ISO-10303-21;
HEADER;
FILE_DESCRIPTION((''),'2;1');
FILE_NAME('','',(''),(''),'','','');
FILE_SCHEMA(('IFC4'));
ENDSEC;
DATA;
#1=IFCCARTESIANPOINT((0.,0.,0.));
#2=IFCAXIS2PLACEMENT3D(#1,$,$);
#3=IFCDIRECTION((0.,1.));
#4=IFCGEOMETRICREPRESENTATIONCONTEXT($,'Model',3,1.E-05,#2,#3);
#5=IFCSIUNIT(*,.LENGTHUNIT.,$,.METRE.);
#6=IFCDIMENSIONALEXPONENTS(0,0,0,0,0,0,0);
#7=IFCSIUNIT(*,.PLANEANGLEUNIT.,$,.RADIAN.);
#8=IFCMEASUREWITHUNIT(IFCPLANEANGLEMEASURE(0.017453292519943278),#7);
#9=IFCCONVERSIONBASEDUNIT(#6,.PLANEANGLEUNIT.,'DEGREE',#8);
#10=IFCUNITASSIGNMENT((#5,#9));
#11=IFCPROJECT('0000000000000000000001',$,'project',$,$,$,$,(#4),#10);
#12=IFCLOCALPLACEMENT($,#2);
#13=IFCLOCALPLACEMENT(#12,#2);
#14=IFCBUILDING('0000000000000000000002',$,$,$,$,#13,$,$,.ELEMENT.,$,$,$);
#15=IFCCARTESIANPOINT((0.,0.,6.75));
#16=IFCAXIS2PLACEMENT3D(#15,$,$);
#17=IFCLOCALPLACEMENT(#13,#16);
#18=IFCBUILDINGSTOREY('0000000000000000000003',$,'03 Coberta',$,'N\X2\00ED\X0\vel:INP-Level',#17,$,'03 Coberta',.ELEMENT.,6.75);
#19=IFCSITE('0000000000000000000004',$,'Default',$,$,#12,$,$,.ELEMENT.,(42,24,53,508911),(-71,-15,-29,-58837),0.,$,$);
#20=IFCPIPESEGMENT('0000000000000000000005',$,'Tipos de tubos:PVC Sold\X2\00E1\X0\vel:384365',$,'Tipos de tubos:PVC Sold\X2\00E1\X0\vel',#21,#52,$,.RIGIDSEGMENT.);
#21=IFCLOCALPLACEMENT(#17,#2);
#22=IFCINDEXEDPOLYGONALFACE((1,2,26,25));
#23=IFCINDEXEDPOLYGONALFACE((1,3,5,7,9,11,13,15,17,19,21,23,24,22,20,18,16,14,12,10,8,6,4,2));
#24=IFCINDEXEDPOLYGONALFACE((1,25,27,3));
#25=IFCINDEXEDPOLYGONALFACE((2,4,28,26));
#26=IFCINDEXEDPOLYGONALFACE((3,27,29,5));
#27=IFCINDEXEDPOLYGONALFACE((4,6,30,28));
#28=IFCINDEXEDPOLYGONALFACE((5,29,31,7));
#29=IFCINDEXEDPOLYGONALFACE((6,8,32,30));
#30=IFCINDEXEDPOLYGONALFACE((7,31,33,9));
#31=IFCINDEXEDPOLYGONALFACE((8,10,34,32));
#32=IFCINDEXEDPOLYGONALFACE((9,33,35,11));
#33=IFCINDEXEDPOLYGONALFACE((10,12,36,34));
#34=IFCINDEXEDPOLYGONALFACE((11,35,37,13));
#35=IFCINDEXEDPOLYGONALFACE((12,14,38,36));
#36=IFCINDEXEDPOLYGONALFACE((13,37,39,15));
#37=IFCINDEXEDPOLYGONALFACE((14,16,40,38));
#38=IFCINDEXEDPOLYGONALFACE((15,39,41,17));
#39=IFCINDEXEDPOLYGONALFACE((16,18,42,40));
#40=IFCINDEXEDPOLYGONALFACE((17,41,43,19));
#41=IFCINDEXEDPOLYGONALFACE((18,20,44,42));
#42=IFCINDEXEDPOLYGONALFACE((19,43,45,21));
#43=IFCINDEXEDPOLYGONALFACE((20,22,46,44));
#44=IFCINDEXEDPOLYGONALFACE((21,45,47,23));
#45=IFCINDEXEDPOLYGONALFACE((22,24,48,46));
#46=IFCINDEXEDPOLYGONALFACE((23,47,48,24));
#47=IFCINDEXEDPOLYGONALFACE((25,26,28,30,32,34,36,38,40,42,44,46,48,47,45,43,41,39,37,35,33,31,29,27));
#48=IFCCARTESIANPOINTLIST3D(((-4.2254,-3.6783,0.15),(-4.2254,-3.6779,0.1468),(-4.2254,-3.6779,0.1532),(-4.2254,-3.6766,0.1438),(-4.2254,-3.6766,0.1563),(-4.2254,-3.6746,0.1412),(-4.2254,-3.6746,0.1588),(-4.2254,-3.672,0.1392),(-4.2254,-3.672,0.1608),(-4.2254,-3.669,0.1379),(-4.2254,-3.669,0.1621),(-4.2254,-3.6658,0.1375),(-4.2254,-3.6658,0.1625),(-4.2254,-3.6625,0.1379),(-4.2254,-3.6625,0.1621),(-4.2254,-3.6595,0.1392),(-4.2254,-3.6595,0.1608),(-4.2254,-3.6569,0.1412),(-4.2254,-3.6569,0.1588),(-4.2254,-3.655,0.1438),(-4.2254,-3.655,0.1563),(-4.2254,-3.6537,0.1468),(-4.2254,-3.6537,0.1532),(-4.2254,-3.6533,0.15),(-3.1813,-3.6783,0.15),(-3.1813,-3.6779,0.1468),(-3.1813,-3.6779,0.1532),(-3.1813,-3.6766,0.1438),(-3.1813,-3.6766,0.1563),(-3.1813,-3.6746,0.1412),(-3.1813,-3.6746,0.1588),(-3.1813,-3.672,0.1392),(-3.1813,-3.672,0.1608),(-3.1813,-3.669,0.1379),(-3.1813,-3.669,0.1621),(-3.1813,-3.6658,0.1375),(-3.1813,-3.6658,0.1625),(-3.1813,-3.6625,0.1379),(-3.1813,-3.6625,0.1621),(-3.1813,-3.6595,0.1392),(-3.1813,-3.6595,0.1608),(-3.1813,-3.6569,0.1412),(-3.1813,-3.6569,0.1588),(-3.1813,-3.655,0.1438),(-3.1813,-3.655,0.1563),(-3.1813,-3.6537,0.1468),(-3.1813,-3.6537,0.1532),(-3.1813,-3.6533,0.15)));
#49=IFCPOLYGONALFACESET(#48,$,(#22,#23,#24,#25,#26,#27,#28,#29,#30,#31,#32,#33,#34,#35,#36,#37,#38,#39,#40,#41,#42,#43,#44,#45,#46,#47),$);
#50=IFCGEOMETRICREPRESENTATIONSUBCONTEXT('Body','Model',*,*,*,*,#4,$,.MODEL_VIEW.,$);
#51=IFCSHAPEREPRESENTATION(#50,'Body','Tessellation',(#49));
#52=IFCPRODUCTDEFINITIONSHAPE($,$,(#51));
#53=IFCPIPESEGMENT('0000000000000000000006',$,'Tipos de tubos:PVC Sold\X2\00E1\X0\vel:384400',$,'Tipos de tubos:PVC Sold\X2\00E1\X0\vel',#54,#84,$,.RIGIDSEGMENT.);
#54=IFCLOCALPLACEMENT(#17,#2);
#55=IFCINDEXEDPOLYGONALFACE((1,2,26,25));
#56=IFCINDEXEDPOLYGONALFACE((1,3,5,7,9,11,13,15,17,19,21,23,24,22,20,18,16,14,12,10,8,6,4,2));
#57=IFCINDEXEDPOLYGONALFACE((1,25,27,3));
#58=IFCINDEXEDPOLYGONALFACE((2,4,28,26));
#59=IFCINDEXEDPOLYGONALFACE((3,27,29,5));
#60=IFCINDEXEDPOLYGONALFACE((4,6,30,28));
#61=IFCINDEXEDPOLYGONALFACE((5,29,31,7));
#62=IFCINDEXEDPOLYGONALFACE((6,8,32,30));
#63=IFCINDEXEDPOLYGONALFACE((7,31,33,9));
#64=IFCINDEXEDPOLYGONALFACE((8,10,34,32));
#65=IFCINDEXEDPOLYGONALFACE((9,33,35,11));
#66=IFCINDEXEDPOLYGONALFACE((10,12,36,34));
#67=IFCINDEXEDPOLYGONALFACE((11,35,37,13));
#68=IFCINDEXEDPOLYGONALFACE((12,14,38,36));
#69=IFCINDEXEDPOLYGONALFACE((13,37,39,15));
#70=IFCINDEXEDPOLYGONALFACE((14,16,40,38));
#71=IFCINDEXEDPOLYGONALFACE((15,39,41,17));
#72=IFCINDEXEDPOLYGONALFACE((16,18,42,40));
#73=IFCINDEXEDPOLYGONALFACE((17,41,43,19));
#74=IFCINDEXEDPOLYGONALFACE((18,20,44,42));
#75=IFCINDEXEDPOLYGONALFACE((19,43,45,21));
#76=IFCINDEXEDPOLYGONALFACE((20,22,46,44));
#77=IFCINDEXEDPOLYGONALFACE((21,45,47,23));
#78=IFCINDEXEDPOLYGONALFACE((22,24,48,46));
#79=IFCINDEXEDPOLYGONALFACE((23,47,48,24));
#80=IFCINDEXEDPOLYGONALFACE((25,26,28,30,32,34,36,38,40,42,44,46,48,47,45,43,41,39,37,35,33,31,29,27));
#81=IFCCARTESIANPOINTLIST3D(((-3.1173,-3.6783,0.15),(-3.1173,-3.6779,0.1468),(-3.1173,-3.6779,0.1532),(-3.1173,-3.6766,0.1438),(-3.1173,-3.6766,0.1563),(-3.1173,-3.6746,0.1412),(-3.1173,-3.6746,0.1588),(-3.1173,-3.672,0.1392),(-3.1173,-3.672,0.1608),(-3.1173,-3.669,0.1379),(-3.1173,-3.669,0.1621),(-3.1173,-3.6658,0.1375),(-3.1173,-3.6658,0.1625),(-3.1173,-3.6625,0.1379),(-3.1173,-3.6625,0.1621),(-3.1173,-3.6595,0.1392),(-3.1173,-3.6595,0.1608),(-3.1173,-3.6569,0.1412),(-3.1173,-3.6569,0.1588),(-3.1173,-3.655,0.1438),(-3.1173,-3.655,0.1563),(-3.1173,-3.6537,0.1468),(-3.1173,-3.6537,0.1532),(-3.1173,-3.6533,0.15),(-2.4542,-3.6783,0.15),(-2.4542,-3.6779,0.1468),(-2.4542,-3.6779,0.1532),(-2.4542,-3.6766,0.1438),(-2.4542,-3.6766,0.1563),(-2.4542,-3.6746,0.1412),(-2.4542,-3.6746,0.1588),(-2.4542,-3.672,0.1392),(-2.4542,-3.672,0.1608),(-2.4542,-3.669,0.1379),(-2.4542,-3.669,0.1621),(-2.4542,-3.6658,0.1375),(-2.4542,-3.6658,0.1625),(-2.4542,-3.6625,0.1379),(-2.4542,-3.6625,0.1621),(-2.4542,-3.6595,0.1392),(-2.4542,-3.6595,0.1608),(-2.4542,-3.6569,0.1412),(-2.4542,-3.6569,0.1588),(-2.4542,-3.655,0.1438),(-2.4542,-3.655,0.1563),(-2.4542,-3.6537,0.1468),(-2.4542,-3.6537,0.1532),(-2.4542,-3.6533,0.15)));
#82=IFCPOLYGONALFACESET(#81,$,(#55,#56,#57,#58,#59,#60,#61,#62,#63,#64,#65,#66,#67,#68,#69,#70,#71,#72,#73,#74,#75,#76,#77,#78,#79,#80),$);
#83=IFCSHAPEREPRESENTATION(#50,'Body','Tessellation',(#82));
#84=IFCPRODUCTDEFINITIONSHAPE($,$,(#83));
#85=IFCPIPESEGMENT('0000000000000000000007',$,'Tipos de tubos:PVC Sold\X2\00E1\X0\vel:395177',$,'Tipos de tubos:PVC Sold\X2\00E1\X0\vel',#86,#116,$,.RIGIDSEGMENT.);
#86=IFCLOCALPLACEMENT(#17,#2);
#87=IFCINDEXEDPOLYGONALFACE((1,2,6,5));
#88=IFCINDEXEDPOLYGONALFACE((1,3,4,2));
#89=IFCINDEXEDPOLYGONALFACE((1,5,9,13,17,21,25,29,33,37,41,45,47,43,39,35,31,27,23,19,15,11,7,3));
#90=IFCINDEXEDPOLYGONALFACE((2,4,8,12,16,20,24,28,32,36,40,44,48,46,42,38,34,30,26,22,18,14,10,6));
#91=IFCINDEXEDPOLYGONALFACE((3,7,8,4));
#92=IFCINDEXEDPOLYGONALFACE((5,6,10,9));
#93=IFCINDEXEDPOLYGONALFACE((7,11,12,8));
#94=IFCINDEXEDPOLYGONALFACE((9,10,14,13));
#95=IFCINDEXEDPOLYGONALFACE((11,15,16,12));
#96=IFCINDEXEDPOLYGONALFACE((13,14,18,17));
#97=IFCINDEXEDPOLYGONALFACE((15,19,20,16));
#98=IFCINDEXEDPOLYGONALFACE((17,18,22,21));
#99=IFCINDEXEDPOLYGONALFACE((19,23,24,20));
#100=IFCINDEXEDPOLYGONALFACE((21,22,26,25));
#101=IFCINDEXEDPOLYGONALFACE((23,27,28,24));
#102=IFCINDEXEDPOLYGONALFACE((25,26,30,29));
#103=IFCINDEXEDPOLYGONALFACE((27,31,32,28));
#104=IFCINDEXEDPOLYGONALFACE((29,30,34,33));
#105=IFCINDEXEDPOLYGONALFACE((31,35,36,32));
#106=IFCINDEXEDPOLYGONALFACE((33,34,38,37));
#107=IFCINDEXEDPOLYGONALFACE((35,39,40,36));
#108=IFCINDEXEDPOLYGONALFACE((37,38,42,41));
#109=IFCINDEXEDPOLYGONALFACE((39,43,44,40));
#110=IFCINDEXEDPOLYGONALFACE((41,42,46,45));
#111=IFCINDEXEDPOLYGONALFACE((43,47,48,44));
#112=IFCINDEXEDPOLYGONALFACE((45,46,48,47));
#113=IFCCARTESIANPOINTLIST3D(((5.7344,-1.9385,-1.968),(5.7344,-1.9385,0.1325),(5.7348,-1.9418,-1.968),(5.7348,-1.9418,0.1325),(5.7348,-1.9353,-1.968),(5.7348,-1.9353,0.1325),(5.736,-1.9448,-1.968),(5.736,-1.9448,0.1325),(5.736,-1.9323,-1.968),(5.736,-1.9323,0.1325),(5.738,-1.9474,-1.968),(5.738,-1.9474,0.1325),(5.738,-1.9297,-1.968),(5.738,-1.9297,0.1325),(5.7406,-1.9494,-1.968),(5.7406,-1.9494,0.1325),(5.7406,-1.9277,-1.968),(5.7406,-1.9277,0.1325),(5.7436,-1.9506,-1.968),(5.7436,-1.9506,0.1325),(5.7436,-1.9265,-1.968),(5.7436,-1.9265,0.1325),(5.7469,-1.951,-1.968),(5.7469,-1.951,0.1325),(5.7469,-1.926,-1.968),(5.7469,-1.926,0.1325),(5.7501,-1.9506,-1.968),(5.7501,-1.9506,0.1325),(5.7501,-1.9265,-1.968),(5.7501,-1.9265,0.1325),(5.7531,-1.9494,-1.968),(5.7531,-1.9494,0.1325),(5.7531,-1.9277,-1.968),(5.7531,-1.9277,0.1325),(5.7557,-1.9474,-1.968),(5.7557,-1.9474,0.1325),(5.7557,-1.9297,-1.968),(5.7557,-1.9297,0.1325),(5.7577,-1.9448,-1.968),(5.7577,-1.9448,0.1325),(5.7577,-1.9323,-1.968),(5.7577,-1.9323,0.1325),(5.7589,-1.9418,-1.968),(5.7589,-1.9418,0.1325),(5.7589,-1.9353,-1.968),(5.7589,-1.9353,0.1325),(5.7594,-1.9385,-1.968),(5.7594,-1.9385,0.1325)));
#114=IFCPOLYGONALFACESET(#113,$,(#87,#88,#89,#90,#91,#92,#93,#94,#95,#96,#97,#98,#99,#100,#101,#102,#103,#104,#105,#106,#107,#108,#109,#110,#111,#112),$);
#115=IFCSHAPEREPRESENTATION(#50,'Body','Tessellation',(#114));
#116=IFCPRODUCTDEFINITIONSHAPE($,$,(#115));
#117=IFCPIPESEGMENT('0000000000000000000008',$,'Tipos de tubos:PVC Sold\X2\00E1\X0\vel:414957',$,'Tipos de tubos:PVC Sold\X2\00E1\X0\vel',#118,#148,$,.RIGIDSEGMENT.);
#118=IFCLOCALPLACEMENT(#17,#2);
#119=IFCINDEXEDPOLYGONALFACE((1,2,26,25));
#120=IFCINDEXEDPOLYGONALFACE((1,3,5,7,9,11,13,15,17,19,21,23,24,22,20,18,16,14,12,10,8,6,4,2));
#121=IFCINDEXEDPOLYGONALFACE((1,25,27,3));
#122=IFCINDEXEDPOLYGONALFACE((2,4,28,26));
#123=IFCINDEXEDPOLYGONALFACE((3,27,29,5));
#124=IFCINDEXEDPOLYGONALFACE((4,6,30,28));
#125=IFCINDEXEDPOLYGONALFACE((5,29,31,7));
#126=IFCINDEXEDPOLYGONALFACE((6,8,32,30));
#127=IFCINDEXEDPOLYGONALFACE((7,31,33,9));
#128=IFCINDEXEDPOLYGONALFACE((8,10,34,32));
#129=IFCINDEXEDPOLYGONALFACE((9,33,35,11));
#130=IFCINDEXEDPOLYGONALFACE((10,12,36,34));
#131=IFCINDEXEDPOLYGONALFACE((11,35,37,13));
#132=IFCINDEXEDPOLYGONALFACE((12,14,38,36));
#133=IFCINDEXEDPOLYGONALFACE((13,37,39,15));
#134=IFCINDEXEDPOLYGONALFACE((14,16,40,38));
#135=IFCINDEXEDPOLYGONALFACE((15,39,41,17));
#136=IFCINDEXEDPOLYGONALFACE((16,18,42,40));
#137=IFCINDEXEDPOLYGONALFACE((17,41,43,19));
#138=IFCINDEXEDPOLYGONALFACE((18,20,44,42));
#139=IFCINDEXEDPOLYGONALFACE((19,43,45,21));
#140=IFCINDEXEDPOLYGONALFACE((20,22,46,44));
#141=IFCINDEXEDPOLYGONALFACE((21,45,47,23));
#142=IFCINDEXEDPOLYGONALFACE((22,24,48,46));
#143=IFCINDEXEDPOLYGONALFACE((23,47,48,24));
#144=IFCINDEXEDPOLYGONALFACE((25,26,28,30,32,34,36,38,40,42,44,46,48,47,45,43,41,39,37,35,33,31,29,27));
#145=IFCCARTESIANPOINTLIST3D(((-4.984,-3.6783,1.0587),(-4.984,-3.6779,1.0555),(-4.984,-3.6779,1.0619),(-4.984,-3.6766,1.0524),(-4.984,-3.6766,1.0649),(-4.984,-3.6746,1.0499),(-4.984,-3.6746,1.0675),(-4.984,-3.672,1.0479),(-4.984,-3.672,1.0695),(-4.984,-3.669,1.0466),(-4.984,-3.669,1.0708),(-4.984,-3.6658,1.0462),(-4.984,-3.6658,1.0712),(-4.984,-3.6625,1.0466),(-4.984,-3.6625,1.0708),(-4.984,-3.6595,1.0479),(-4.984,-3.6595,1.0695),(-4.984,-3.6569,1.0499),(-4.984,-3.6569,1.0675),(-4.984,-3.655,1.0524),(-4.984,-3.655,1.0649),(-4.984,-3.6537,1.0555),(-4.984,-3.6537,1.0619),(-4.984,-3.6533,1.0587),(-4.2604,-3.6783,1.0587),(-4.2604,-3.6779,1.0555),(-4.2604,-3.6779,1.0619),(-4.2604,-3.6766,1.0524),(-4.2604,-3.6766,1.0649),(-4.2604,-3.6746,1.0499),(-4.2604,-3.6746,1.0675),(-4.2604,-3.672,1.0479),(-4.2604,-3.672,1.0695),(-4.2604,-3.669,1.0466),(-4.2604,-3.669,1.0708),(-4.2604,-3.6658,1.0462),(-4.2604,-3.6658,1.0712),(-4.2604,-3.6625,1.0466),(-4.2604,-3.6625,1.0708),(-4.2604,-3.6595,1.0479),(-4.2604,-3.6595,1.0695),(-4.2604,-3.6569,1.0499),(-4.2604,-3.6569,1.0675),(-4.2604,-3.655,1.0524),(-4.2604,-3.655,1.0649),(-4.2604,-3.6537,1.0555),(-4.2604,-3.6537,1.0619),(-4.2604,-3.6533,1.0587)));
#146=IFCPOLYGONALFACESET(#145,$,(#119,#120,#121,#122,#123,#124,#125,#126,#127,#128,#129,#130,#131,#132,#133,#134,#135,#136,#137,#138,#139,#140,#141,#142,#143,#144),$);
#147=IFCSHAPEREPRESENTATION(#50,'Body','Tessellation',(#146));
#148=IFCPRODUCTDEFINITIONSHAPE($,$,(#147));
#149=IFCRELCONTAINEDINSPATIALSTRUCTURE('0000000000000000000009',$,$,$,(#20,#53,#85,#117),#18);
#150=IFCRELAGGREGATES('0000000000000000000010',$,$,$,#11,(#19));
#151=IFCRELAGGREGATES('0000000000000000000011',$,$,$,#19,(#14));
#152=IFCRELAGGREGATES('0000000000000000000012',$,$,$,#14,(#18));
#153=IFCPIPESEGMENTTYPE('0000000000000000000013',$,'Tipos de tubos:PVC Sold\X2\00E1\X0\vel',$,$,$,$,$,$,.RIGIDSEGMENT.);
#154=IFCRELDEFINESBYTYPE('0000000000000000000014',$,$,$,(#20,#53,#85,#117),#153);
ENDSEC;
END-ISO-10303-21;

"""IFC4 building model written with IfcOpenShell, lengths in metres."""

from ifc_helpers import new_model, entity, si_unit, converted_unit, direction, frame, origin, place, context, subcontext, project, spatial, arc, indexed_curve, outline, extrude, type_object, element, save


model = new_model("IFC4")

# Units and contexts
model_context = context("Model", 3, precision=1e-05, world=origin(), true_north=direction((0.0, 1.0)))
body_context = subcontext(model_context, "Body", "Model", "MODEL_VIEW")
ifc_project = project(units=[si_unit("LENGTHUNIT", "METRE"), converted_unit("PLANEANGLEUNIT", "DEGREE", entity("IfcPlaneAngleMeasure", 0.017453292519943278), si_unit("PLANEANGLEUNIT", "RADIAN"), dimensions=[0, 0, 0, 0, 0, 0, 0])], contexts=[model_context])

# Site, building, storey
site_placement = place(None, origin())
site = spatial("IfcSite", under=ifc_project, at=site_placement, Name="Default", CompositionType="ELEMENT", RefLatitude=(42, 24, 53, 508911), RefLongitude=(-71, -15, -29, -58837), RefElevation=0.0)
building_placement = place(site_placement, origin())
building = spatial("IfcBuilding", under=site, at=building_placement, CompositionType="ELEMENT")
storey_placement = place(building_placement, frame((0.0, 0.0, 6.75)))
storey = spatial("IfcBuildingStorey", under=building, at=storey_placement, Name="03 Coberta", ObjectType="Nível:INP-Level", LongName="03 Coberta", CompositionType="ELEMENT", Elevation=6.75)

# Pipe segments
pipe_segment_type = type_object("IfcPipeSegmentType", Name="Tipos de tubos:PVC Soldável", PredefinedType="RIGIDSEGMENT")
pipe_segment_1_placement = place(storey_placement, origin())
element("IfcPipeSegment", 1, at=pipe_segment_1_placement, inside=storey, type_object=pipe_segment_type, Name="Tipos de tubos:PVC Soldável:384365", ObjectType="Tipos de tubos:PVC Soldável", PredefinedType="RIGIDSEGMENT", context=body_context, shape_type="SweptSolid", body=[
    extrude(outline(indexed_curve([(0.0125, 0.0), (0.0088, 0.0088), (0.0, 0.0125), (-0.0088, 0.0088), (-0.0125, 0.0), (-0.0088, -0.0088), (0.0, -0.0125), (0.0088, -0.0088)], segments=[arc(1, 2, 3), arc(3, 4, 5), arc(5, 6, 7), arc(7, 8, 1)], self_intersect=False)), frame((-4.2254, -3.6658, 0.15), z_axis=(1.0, 0.0, 0.0), x_axis=(0.0, -1.0, 0.0)), (0.0, 0.0, 1.0), 1.044),
])
pipe_segment_2_placement = place(storey_placement, origin())
element("IfcPipeSegment", 2, at=pipe_segment_2_placement, inside=storey, type_object=pipe_segment_type, Name="Tipos de tubos:PVC Soldável:384400", ObjectType="Tipos de tubos:PVC Soldável", PredefinedType="RIGIDSEGMENT", context=body_context, shape_type="SweptSolid", body=[
    extrude(outline(indexed_curve([(0.0125, 0.0), (0.0088, 0.0088), (0.0, 0.0125), (-0.0088, 0.0088), (-0.0125, 0.0), (-0.0088, -0.0088), (0.0, -0.0125), (0.0088, -0.0088)], segments=[arc(1, 2, 3), arc(3, 4, 5), arc(5, 6, 7), arc(7, 8, 1)], self_intersect=False)), frame((-3.1173, -3.6658, 0.15), z_axis=(1.0, 0.0, 0.0), x_axis=(0.0, -1.0, 0.0)), (0.0, 0.0, 1.0), 0.6631),
])
pipe_segment_3_placement = place(storey_placement, origin())
element("IfcPipeSegment", 3, at=pipe_segment_3_placement, inside=storey, type_object=pipe_segment_type, Name="Tipos de tubos:PVC Soldável:395177", ObjectType="Tipos de tubos:PVC Soldável", PredefinedType="RIGIDSEGMENT", context=body_context, shape_type="SweptSolid", body=[
    extrude(outline(indexed_curve([(0.0125, 0.0), (0.0088, 0.0088), (0.0, 0.0125), (-0.0088, 0.0088), (-0.0125, 0.0), (-0.0088, -0.0088), (0.0, -0.0125), (0.0088, -0.0088)], segments=[arc(1, 2, 3), arc(3, 4, 5), arc(5, 6, 7), arc(7, 8, 1)], self_intersect=False)), frame((5.7469, -1.9385, -1.968)), (0.0, 0.0, 1.0), 2.1005),
])
pipe_segment_4_placement = place(storey_placement, origin())
element("IfcPipeSegment", 4, at=pipe_segment_4_placement, inside=storey, type_object=pipe_segment_type, Name="Tipos de tubos:PVC Soldável:414957", ObjectType="Tipos de tubos:PVC Soldável", PredefinedType="RIGIDSEGMENT", context=body_context, shape_type="SweptSolid", body=[
    extrude(outline(indexed_curve([(0.0125, 0.0), (0.0088, 0.0088), (0.0, 0.0125), (-0.0088, 0.0088), (-0.0125, 0.0), (-0.0088, -0.0088), (0.0, -0.0125), (0.0088, -0.0088)], segments=[arc(1, 2, 3), arc(3, 4, 5), arc(5, 6, 7), arc(7, 8, 1)], self_intersect=False)), frame((-4.984, -3.6658, 1.0587), z_axis=(1.0, 0.0, 0.0), x_axis=(0.0, -1.0, 0.0)), (0.0, 0.0, 1.0), 0.7237),
])

save(model, "model.ifc")
